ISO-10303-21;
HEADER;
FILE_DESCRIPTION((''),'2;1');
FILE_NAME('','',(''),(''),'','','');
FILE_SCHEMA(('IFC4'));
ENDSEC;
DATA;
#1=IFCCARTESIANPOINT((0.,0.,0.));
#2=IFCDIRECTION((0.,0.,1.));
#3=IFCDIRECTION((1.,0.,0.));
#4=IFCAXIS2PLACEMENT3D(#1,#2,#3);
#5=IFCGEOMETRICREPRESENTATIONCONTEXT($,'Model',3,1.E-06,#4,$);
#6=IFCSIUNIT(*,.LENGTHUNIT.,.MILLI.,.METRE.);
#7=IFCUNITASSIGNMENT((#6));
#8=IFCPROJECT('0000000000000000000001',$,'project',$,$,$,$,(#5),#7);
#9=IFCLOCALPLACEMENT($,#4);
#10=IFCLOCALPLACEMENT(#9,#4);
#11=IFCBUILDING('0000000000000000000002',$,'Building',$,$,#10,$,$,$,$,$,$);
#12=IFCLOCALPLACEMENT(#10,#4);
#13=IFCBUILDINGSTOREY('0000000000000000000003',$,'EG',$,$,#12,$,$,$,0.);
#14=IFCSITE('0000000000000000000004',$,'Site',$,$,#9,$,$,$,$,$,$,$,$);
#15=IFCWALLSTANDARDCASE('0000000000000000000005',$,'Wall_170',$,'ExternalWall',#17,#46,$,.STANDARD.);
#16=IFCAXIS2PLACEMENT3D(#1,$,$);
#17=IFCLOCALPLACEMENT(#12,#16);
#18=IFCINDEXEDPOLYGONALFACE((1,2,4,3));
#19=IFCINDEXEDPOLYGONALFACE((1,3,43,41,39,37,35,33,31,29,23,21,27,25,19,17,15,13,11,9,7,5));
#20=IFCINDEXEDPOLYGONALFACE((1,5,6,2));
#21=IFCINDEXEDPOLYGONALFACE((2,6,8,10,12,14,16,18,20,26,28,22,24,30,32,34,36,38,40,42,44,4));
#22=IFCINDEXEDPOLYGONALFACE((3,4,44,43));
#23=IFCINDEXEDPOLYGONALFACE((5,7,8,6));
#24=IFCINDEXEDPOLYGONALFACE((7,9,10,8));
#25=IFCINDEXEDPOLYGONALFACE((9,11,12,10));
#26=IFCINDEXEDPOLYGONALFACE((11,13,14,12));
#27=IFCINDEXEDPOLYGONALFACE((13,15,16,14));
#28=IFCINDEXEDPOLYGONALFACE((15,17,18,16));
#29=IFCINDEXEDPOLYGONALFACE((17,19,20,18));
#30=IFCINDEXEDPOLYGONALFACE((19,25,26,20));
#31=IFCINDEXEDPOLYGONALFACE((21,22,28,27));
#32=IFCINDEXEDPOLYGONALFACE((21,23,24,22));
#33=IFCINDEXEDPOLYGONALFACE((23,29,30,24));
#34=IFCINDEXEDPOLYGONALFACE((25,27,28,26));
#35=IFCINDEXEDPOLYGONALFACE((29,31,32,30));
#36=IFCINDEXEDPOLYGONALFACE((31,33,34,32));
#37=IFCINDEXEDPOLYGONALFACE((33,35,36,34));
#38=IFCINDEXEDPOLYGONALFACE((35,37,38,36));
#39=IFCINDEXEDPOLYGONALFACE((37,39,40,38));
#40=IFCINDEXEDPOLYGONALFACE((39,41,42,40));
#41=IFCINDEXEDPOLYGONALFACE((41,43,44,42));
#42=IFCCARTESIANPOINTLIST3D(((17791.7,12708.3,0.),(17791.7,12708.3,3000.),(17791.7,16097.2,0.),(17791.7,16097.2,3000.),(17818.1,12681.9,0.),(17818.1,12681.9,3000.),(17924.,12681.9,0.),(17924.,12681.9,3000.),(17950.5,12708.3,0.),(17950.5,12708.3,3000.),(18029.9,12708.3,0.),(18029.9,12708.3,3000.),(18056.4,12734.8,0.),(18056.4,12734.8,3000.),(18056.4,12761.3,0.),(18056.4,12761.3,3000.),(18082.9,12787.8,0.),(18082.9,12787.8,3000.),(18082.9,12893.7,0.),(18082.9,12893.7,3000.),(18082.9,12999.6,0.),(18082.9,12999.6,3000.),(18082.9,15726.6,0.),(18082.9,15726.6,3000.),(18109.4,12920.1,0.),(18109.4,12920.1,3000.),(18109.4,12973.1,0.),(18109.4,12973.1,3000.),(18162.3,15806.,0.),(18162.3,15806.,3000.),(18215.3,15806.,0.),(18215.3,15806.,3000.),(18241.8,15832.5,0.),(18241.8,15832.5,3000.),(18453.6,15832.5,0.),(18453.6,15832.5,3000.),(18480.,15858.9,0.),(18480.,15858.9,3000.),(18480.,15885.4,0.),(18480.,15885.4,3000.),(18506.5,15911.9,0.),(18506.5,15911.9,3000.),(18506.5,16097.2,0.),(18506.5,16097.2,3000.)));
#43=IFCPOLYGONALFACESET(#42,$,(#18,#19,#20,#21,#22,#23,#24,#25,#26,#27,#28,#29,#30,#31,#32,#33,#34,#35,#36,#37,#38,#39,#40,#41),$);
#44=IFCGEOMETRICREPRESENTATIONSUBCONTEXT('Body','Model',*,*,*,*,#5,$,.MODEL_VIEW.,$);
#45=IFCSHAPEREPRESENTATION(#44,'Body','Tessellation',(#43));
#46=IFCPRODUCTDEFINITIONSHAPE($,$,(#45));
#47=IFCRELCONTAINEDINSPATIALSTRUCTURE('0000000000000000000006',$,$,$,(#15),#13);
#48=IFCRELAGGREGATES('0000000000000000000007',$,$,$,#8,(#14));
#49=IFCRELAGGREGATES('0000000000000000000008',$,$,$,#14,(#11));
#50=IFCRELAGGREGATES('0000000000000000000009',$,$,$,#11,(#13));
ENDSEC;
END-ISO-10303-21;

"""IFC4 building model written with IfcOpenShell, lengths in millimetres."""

from ifc_helpers import new_model, si_unit, frame, origin_with_axes, place, context, subcontext, project, spatial, polyline, outline, extrude, element, save


model = new_model("IFC4")

# Units and contexts
model_context = context("Model", 3, precision=1e-06, world=origin_with_axes())
body_context = subcontext(model_context, "Body", "Model", "MODEL_VIEW")
ifc_project = project(units=[si_unit("LENGTHUNIT", "METRE", prefix="MILLI")], contexts=[model_context])

# Site, building, storey
site_placement = place(None, origin_with_axes())
site = spatial("IfcSite", under=ifc_project, at=site_placement, Name="Site")
building_placement = place(site_placement, origin_with_axes())
building = spatial("IfcBuilding", under=site, at=building_placement, Name="Building")
storey_placement = place(building_placement, origin_with_axes())
storey = spatial("IfcBuildingStorey", under=building, at=storey_placement, Name="EG", Elevation=0.0)

# Wall
for number, where, z_axis, x_axis, name in (
    (1, (0.0, 0.0, 0.0), (0.0, 0.0, 1.0), (1.0, 0.0, 0.0), "Wall_170"),
):
    element("IfcWallStandardCase", number, at=place(storey_placement, frame(where, z_axis=z_axis, x_axis=x_axis)), inside=storey, Name=name, ObjectType="ExternalWall", PredefinedType="STANDARD", context=body_context, shape_type="SweptSolid", body=[
        extrude(outline(polyline([(17818.1, 12681.9, 0.0), (17791.7, 12708.3, 0.0), (17791.7, 16097.2, 0.0), (18506.5, 16097.2, 0.0), (18506.5, 15911.9, 0.0), (18480.0, 15885.4, 0.0), (18480.0, 15858.9, 0.0), (18453.6, 15832.5, 0.0), (18241.8, 15832.5, 0.0), (18215.3, 15806.0, 0.0), (18162.3, 15806.0, 0.0), (18082.9, 15726.6, 0.0), (18082.9, 12999.6, 0.0), (18109.4, 12973.1, 0.0), (18109.4, 12920.1, 0.0), (18082.9, 12893.7, 0.0), (18082.9, 12787.8, 0.0), (18056.4, 12761.3, 0.0), (18056.4, 12734.8, 0.0), (18029.9, 12708.3, 0.0), (17950.5, 12708.3, 0.0), (17924.0, 12681.9, 0.0), (17818.1, 12681.9, 0.0)])), origin_with_axes(), (0.0, 0.0, 1.0), 3000.0),
    ])

save(model, "model.ifc")
